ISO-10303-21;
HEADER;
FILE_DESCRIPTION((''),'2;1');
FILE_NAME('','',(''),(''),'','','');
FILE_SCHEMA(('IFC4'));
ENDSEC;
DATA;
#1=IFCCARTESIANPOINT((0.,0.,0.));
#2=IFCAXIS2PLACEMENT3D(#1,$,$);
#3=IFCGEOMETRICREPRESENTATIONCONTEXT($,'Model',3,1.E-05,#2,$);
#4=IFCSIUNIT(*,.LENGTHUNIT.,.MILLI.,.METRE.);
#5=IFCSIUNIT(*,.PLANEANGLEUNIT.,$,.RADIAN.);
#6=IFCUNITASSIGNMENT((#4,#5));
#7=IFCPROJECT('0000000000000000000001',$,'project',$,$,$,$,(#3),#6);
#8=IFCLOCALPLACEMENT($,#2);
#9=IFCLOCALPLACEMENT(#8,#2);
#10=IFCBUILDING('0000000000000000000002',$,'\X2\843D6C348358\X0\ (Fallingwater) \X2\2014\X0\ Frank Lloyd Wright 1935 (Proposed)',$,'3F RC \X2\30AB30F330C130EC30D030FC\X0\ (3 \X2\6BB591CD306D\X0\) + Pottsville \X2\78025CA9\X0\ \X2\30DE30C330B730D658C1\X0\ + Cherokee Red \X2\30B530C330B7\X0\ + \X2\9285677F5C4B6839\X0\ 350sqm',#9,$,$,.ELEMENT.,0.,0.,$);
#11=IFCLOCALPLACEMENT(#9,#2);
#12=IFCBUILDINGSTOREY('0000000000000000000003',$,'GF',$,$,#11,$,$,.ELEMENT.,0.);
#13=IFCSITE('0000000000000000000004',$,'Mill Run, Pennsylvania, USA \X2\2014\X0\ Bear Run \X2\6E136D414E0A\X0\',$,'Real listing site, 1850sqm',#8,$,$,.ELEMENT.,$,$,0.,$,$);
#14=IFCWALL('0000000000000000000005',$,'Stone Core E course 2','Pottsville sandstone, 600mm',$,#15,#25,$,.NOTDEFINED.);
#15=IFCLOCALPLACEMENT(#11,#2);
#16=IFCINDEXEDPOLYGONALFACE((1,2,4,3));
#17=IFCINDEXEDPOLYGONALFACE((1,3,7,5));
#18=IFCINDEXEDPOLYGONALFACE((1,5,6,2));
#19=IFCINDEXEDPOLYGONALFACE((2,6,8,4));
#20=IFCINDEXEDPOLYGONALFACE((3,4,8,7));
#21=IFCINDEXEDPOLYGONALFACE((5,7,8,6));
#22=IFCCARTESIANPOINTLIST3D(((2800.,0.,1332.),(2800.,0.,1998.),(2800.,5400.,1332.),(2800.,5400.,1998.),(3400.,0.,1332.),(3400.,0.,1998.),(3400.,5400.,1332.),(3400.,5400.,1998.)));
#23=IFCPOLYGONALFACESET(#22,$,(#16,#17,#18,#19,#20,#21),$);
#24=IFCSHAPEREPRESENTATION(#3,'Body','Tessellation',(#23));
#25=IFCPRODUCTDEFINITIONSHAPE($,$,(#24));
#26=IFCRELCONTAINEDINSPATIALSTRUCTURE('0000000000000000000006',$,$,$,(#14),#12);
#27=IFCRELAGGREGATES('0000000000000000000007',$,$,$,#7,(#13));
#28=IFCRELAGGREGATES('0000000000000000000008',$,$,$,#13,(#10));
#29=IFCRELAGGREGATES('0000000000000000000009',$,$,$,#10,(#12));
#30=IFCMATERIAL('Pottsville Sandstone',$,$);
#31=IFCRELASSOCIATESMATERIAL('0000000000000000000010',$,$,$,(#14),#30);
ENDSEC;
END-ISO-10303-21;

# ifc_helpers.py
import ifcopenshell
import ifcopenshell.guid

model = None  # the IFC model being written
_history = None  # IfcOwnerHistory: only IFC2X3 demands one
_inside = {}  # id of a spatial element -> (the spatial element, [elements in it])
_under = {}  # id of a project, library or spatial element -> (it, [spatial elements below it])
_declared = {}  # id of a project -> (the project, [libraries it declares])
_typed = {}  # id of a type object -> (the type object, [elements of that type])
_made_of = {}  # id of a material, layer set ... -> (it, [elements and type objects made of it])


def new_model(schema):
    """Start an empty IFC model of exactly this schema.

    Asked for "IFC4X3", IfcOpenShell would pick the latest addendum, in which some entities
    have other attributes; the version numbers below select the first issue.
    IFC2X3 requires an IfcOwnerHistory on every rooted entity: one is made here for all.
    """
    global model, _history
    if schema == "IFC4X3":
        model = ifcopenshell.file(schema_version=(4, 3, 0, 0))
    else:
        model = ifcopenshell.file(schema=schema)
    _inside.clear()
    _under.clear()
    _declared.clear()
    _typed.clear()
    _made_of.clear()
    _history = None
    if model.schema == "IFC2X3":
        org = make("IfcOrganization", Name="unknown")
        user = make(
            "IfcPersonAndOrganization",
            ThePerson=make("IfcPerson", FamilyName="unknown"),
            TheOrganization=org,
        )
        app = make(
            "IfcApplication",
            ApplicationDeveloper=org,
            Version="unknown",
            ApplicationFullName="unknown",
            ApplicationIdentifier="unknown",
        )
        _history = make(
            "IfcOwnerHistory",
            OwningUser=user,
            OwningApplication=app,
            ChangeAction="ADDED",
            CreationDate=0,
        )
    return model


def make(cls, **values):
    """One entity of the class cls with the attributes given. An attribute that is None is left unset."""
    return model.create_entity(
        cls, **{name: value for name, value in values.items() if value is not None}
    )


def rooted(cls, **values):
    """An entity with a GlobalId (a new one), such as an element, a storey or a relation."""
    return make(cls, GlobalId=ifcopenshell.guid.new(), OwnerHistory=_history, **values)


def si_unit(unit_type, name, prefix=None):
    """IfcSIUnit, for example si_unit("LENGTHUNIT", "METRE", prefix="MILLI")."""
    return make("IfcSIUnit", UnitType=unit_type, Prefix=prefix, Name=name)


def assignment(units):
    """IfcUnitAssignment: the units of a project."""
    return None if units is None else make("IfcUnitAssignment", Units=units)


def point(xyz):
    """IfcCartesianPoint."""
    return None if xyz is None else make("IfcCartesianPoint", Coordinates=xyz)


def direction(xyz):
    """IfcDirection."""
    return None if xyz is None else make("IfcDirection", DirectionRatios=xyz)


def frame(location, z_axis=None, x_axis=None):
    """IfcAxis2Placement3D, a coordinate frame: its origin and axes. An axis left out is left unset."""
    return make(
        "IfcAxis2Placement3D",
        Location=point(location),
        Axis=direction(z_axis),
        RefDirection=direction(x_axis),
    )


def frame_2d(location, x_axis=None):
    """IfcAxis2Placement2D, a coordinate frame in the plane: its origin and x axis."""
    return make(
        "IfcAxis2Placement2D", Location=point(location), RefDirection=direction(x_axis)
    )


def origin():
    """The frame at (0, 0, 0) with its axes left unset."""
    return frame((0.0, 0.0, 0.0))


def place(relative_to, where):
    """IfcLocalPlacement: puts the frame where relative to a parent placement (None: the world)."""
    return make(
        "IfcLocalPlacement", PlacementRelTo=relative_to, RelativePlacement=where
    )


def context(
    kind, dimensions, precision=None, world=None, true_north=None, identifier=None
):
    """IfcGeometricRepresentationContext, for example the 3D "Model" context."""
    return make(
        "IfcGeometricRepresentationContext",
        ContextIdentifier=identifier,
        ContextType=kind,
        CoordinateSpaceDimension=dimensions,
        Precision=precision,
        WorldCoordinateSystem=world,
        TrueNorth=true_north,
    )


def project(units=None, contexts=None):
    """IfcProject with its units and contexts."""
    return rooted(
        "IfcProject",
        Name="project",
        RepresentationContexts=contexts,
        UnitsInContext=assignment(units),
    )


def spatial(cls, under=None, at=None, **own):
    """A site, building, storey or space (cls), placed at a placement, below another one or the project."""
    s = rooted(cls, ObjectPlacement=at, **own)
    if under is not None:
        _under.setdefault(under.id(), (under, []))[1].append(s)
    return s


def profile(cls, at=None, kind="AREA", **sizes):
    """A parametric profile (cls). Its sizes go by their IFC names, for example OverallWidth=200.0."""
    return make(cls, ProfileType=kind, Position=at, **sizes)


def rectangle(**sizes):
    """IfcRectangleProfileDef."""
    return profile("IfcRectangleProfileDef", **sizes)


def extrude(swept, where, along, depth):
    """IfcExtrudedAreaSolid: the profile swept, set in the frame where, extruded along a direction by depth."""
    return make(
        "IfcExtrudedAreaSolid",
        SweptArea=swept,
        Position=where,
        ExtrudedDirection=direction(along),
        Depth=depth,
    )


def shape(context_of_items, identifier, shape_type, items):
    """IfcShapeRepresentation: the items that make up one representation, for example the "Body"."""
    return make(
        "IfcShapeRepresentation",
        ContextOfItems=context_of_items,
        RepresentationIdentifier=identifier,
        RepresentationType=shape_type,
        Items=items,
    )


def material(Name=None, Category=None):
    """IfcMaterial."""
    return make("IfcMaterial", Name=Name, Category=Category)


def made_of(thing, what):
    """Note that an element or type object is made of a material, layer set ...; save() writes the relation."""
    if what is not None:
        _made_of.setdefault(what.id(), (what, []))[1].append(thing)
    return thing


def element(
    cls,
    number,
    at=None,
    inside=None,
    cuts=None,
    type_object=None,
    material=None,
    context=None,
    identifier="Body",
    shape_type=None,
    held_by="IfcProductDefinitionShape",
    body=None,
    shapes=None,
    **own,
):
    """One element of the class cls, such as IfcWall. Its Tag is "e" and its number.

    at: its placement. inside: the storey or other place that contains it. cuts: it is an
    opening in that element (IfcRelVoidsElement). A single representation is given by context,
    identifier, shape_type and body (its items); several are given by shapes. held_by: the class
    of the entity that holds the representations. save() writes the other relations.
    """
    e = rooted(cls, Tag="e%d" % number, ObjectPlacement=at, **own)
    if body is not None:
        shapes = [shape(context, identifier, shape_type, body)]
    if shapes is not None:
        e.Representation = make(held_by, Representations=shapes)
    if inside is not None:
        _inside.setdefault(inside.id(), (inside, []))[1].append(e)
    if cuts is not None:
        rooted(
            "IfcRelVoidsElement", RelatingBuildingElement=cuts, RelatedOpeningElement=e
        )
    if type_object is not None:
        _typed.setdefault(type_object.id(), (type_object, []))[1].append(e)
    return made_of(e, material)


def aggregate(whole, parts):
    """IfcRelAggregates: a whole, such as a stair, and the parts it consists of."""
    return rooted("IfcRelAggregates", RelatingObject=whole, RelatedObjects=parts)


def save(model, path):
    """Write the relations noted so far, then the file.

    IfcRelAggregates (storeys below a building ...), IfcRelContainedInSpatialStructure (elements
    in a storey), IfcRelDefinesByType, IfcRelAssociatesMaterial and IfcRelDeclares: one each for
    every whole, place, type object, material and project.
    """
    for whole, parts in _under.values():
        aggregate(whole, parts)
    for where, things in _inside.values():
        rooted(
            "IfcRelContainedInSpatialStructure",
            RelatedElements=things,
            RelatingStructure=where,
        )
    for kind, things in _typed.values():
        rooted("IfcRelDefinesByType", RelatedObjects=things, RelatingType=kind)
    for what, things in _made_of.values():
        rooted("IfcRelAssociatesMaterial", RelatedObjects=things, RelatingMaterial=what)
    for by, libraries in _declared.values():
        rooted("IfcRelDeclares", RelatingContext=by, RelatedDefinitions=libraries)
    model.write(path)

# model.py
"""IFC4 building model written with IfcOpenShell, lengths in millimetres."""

from ifc_helpers import new_model, si_unit, frame, frame_2d, origin, place, context, project, spatial, rectangle, extrude, material, element, save


model = new_model("IFC4")

# Units and contexts
model_context = context("Model", 3, precision=1e-05, world=origin())
ifc_project = project(units=[si_unit("LENGTHUNIT", "METRE", prefix="MILLI"), si_unit("PLANEANGLEUNIT", "RADIAN")], contexts=[model_context])

# Site, building, storey
site_placement = place(None, origin())
site = spatial("IfcSite", under=ifc_project, at=site_placement, Name="Mill Run, Pennsylvania, USA — Bear Run 渓流上", ObjectType="Real listing site, 1850sqm", CompositionType="ELEMENT", RefElevation=0.0)
building_placement = place(site_placement, origin())
building = spatial("IfcBuilding", under=site, at=building_placement, Name="落水荘 (Fallingwater) — Frank Lloyd Wright 1935 (Proposed)", ObjectType="3F RC カンチレバー (3 段重ね) + Pottsville 砂岩 マッシブ壁 + Cherokee Red サッシ + 銅板屋根 350sqm", CompositionType="ELEMENT", ElevationOfRefHeight=0.0, ElevationOfTerrain=0.0)
storey_placement = place(building_placement, origin())
storey = spatial("IfcBuildingStorey", under=building, at=storey_placement, Name="GF", CompositionType="ELEMENT", Elevation=0.0)

# Wall
ifc_material_1 = material(Name="Pottsville Sandstone")
wall_1_placement = place(storey_placement, frame((1400.0, 0.0, 666.0)))
element("IfcWall", 1, at=wall_1_placement, inside=storey, material=ifc_material_1, Name="Stone Core E course 2", Description="Pottsville sandstone, 600mm", PredefinedType="NOTDEFINED", context=model_context, shape_type="SweptSolid", body=[
    extrude(rectangle(XDim=600.0, YDim=5400.0, at=frame_2d((300.0, 2700.0))), frame((1400.0, 0.0, 666.0)), (0.0, 0.0, 1.0), 666.0),
])

save(model, "model.ifc")
